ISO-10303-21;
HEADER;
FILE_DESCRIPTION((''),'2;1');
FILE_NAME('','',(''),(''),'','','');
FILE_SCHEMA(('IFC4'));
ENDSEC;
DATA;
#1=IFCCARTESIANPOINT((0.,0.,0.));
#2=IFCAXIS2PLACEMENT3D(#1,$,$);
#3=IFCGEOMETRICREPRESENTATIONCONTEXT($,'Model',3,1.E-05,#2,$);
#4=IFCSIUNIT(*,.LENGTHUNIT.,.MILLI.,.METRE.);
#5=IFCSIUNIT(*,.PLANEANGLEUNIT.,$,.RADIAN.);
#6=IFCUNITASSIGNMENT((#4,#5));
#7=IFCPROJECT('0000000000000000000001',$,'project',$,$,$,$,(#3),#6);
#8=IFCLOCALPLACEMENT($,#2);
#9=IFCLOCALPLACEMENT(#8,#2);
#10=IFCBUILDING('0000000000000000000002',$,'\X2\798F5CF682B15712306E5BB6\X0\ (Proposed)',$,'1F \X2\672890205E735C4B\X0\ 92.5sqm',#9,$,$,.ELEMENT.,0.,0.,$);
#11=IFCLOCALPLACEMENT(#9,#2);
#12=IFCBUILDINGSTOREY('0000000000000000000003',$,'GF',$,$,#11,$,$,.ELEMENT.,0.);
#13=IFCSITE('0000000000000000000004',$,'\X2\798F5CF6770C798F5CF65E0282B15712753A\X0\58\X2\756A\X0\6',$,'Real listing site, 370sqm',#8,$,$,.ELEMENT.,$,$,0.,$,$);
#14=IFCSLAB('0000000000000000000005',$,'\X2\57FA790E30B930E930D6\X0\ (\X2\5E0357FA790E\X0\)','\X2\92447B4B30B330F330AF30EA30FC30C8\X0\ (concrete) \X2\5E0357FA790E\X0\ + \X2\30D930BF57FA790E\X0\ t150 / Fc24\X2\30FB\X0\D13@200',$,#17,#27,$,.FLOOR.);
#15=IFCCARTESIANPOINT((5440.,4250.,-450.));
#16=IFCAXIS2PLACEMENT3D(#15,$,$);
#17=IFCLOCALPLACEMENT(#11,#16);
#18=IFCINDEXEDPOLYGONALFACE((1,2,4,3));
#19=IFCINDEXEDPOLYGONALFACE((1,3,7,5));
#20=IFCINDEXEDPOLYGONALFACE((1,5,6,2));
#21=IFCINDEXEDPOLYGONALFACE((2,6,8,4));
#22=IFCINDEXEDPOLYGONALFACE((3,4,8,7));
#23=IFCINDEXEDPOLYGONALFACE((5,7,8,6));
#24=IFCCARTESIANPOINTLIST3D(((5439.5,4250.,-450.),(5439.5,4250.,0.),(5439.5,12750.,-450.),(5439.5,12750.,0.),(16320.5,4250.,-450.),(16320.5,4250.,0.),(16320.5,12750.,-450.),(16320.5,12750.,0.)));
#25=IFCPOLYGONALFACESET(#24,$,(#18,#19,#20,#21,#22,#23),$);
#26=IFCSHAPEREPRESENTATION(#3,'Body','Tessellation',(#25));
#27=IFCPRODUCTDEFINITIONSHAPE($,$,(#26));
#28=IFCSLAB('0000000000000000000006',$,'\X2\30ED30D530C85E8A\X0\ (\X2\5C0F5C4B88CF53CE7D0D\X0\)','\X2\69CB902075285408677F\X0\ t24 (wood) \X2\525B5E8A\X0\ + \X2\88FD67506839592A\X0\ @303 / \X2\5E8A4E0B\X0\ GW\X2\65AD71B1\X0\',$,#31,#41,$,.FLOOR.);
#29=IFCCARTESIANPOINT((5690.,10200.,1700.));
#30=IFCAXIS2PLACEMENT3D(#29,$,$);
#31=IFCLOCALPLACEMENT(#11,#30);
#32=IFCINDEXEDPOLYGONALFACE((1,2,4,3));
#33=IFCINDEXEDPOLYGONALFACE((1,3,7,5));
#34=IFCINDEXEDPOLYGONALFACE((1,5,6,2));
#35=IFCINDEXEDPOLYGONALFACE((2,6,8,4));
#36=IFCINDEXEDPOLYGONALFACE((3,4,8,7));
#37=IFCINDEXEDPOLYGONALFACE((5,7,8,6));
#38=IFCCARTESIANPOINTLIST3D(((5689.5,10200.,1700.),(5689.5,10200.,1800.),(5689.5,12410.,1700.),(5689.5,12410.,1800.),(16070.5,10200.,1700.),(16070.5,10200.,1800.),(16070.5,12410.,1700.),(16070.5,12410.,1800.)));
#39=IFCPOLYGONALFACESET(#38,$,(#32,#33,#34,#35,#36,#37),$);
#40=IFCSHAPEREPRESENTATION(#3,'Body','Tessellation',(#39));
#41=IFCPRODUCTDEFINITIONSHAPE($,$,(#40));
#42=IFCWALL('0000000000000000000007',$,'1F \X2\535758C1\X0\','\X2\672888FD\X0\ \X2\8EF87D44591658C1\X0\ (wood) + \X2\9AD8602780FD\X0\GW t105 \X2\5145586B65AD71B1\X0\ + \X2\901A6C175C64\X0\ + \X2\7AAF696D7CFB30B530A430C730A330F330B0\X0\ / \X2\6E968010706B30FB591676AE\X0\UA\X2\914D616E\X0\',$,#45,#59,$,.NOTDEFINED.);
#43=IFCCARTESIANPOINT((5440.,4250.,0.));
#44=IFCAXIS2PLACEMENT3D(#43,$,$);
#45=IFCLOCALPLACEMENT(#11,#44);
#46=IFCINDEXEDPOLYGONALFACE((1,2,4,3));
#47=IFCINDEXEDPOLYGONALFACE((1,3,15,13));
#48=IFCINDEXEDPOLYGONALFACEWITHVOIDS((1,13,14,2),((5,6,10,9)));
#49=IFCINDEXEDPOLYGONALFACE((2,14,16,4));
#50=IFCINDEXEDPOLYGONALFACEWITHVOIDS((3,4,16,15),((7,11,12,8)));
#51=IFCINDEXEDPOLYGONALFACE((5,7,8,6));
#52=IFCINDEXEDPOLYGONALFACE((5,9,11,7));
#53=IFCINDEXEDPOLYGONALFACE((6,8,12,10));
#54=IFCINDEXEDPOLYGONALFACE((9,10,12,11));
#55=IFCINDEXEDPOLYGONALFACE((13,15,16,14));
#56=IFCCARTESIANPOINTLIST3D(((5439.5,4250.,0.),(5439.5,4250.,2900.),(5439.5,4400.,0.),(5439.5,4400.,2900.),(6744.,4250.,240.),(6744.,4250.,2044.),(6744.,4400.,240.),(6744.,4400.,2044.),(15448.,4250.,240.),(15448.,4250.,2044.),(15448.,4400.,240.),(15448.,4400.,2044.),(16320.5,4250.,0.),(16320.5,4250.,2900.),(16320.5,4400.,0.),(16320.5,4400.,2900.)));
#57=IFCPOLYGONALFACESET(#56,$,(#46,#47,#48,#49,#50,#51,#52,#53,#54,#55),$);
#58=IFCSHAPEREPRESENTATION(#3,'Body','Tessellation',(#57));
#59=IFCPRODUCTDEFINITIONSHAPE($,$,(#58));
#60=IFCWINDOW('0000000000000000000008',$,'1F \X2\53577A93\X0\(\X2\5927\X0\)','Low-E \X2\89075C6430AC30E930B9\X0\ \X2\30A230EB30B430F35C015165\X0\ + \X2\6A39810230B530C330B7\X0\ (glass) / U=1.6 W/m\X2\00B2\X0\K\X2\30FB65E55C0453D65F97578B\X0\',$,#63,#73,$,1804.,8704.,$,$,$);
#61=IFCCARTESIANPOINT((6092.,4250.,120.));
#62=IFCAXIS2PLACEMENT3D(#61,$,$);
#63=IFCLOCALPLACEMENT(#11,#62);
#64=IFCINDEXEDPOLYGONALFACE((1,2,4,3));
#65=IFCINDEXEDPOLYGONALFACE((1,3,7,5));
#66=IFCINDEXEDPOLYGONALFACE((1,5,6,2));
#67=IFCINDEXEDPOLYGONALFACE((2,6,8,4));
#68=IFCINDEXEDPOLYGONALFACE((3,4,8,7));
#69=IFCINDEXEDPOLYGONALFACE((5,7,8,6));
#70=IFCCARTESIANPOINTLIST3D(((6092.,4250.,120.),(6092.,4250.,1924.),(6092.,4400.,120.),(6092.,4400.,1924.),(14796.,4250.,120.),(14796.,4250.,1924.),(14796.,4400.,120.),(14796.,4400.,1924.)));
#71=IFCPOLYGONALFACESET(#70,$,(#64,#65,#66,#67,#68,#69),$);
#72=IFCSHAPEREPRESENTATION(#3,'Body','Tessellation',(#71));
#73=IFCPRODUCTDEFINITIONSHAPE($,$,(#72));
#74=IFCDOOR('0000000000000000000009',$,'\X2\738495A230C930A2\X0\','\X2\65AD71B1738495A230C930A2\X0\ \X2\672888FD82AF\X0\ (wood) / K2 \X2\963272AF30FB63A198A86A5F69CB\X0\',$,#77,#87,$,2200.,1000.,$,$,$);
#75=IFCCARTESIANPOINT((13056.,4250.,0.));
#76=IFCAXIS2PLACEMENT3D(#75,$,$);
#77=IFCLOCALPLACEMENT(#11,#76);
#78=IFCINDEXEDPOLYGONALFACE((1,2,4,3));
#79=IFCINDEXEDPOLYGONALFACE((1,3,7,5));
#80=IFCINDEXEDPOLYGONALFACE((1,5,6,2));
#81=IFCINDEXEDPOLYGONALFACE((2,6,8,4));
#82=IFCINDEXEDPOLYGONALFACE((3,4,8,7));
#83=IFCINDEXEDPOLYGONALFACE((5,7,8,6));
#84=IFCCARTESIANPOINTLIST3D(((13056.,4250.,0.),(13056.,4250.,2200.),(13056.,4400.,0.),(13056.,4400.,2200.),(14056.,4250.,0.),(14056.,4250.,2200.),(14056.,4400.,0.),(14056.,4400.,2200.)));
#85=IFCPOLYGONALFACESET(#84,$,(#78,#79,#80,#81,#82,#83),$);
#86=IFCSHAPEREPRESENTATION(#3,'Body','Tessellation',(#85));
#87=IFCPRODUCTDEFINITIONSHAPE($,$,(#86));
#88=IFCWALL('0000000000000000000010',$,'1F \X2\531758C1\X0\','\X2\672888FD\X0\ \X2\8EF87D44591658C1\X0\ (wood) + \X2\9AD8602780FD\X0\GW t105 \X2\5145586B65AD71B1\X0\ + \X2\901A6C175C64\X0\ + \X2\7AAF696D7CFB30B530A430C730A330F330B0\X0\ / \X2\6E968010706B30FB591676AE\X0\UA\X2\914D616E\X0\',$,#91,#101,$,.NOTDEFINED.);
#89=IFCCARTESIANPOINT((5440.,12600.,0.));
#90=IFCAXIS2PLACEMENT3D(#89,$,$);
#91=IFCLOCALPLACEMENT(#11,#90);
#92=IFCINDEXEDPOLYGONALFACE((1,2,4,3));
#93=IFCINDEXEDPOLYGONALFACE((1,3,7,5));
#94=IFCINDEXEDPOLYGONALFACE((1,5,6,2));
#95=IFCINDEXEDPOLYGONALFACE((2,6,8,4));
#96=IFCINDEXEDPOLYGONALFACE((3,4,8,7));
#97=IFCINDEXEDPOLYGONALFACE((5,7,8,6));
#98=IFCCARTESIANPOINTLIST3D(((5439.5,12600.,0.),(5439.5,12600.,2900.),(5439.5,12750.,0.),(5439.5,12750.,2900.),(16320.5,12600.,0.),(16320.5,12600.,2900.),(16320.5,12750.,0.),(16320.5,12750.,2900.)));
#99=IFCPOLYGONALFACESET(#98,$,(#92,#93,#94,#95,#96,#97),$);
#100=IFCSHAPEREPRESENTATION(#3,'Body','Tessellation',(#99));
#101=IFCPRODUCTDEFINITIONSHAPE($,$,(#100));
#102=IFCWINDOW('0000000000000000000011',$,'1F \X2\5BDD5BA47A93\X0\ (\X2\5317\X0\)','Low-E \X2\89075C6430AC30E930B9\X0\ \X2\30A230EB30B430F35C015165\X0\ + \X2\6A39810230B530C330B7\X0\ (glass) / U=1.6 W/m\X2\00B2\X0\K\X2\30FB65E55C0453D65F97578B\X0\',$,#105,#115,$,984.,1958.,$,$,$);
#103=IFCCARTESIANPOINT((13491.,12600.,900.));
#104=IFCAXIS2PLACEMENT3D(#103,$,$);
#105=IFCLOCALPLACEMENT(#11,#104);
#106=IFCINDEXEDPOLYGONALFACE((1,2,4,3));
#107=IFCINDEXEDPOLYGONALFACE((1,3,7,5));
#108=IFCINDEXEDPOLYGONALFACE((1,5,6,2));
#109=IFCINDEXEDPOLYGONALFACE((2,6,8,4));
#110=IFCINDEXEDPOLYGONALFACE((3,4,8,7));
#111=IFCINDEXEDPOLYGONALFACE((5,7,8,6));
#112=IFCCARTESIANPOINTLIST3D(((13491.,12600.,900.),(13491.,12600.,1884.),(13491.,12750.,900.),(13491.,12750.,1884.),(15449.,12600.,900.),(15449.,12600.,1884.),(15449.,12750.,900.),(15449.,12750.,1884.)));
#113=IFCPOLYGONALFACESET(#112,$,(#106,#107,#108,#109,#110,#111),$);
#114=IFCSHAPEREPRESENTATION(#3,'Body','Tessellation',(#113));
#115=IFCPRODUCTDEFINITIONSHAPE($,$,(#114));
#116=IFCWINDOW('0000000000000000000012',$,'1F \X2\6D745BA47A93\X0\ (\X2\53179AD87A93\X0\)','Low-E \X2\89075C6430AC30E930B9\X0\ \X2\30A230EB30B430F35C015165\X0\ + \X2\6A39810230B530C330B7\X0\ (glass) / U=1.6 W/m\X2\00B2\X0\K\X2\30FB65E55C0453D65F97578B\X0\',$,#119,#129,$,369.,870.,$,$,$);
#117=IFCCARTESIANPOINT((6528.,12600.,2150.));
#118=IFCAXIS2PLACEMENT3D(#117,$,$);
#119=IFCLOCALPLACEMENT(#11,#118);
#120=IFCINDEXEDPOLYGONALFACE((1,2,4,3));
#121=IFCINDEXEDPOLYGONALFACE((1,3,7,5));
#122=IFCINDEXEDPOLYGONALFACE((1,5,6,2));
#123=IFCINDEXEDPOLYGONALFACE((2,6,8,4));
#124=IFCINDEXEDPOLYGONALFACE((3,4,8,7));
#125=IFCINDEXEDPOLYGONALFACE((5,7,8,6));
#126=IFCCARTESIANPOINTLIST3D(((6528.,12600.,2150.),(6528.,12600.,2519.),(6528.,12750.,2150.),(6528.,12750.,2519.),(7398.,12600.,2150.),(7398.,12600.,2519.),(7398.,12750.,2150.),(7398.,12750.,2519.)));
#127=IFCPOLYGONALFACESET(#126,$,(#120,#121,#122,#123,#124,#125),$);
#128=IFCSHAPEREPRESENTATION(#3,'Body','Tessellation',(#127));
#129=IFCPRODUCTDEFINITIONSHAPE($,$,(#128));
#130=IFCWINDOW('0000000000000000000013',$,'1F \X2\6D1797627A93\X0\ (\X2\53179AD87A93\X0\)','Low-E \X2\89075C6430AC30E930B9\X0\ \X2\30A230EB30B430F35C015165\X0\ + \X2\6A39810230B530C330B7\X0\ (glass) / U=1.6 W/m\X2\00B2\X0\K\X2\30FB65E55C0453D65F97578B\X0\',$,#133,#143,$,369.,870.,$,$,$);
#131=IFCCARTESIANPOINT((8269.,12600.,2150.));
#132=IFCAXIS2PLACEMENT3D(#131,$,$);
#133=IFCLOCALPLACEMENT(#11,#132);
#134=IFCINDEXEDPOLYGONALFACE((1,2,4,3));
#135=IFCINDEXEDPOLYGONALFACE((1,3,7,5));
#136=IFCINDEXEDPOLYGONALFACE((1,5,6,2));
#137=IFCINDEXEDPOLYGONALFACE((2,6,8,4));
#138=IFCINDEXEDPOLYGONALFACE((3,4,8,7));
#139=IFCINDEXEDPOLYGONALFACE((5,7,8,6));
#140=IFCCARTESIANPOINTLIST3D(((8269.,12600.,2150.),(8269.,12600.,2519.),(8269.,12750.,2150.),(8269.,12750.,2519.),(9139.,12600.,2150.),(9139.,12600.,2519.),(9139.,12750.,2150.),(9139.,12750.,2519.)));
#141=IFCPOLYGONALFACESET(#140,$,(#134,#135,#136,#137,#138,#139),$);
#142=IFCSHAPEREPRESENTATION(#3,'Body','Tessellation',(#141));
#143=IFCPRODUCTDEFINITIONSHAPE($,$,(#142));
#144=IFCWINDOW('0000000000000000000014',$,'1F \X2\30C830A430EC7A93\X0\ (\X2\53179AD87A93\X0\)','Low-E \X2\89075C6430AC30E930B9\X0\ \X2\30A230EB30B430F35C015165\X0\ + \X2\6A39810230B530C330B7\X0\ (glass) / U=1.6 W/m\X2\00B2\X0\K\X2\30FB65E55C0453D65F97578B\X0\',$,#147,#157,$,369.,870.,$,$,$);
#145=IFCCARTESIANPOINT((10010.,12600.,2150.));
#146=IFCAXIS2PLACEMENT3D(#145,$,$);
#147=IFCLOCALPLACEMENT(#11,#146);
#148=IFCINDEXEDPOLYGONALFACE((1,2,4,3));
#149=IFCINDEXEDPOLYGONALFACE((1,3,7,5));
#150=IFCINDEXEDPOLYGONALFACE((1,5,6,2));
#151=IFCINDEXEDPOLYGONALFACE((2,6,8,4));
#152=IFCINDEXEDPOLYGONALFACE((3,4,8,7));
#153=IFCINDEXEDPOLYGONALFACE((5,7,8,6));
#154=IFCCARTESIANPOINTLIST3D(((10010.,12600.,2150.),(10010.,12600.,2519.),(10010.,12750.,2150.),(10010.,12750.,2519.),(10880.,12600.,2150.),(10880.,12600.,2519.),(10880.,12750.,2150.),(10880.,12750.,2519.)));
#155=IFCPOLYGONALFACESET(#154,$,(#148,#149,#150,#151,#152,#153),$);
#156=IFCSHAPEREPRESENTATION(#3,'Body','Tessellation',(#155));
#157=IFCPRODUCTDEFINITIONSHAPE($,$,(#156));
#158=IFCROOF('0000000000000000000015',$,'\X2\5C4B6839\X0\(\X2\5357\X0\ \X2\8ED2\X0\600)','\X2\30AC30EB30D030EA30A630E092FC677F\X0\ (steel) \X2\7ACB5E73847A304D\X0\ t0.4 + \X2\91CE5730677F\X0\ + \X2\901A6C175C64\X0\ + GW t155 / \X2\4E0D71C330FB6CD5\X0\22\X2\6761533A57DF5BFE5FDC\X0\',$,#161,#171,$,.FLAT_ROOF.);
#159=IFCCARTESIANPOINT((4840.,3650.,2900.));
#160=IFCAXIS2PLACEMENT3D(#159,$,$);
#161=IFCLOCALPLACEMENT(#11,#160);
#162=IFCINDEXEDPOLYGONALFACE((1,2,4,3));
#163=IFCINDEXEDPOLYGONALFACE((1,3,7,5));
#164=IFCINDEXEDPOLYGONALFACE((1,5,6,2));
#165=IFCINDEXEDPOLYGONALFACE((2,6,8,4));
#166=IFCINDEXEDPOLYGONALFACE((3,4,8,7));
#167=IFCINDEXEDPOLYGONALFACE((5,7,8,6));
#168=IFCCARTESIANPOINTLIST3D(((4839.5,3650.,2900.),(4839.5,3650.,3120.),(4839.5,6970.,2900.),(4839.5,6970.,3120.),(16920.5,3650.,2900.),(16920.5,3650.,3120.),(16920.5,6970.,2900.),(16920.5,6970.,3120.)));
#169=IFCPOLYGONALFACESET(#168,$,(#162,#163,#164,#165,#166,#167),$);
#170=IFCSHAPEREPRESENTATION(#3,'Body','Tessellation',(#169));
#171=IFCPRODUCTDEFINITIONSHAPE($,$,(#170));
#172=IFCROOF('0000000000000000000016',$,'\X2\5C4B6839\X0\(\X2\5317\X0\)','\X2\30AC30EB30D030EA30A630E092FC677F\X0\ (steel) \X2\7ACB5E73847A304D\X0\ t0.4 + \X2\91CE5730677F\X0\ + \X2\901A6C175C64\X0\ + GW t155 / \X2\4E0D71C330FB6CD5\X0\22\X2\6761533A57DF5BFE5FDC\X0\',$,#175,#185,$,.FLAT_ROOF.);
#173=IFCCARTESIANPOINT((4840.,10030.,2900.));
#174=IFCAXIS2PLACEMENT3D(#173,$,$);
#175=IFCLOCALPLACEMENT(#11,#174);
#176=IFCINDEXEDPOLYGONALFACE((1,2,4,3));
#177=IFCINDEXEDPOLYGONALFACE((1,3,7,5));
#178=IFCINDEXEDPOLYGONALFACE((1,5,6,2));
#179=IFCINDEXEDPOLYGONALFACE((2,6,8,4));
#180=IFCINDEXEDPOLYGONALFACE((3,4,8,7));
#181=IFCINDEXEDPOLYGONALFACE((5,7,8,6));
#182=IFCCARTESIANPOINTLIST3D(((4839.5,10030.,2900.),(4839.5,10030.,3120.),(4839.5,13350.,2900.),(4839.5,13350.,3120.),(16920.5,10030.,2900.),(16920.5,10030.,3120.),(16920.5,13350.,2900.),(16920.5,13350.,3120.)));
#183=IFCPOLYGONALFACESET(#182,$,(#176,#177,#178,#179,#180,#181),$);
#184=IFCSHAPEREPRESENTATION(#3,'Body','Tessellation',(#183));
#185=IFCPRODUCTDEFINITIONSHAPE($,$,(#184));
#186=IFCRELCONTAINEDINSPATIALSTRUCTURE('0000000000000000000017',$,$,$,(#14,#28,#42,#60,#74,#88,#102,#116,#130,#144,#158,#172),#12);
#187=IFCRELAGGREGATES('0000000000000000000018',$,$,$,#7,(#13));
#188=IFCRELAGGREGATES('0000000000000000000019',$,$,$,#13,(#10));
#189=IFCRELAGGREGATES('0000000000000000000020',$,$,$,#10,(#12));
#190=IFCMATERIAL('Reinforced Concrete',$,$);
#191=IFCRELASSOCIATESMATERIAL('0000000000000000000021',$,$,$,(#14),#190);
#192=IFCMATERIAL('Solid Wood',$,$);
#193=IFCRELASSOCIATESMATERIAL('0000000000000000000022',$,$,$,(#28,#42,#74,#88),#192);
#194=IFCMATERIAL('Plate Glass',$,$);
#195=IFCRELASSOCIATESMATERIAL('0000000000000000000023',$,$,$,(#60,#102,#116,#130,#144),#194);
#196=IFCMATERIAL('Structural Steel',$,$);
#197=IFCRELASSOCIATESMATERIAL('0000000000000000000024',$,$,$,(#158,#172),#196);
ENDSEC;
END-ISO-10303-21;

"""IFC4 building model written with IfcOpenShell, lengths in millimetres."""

from ifc_helpers import new_model, si_unit, frame, frame_2d, origin, place, context, project, spatial, rectangle, extrude, material, element, fill, save


model = new_model("IFC4")

# Units and contexts
model_context = context("Model", 3, precision=1e-05, world=origin())
ifc_project = project(units=[si_unit("LENGTHUNIT", "METRE", prefix="MILLI"), si_unit("PLANEANGLEUNIT", "RADIAN")], contexts=[model_context])

# Site, building, storey
site_placement = place(None, origin())
site = spatial("IfcSite", under=ifc_project, at=site_placement, Name="福島県福島市花園町58番6", ObjectType="Real listing site, 370sqm", CompositionType="ELEMENT", RefElevation=0.0)
building_placement = place(site_placement, origin())
building = spatial("IfcBuilding", under=site, at=building_placement, Name="福島花園の家 (Proposed)", ObjectType="1F 木造平屋 92.5sqm", CompositionType="ELEMENT", ElevationOfRefHeight=0.0, ElevationOfTerrain=0.0)
storey_placement = place(building_placement, origin())
storey = spatial("IfcBuildingStorey", under=building, at=storey_placement, Name="GF", CompositionType="ELEMENT", Elevation=0.0)

# Slabs
ifc_material_1 = material(Name="Reinforced Concrete")
slab_1_placement = place(storey_placement, frame((5440.0, 4250.0, -450.0)))
element("IfcSlab", 1, at=slab_1_placement, inside=storey, material=ifc_material_1, Name="基礎スラブ (布基礎)", Description="鉄筋コンクリート (concrete) 布基礎 + ベタ基礎 t150 / Fc24・D13@200", PredefinedType="FLOOR", context=model_context, shape_type="SweptSolid", body=[
    extrude(rectangle(XDim=10881.0, YDim=8500.0, at=frame_2d((5440.0, 4250.0))), frame((5440.0, 4250.0, -450.0)), (0.0, 0.0, 1.0), 450.0),
])
ifc_material_2 = material(Name="Solid Wood")
slab_2_placement = place(storey_placement, frame((5690.0, 10200.0, 1700.0)))
element("IfcSlab", 2, at=slab_2_placement, inside=storey, material=ifc_material_2, Name="ロフト床 (小屋裏収納)", Description="構造用合板 t24 (wood) 剛床 + 製材根太 @303 / 床下 GW断熱", PredefinedType="FLOOR", context=model_context, shape_type="SweptSolid", body=[
    extrude(rectangle(XDim=10381.0, YDim=2210.0, at=frame_2d((5190.0, 1105.0))), frame((5690.0, 10200.0, 1700.0)), (0.0, 0.0, 1.0), 100.0),
])

# Wall, openings, window, door
wall_1_placement = place(storey_placement, frame((5440.0, 4250.0, 0.0)))
wall_1 = element("IfcWall", 3, at=wall_1_placement, inside=storey, material=ifc_material_2, Name="1F 南壁", Description="木製 軸組外壁 (wood) + 高性能GW t105 充填断熱 + 通気層 + 窯業系サイディング / 準耐火・外皮UA配慮", PredefinedType="NOTDEFINED", context=model_context, shape_type="SweptSolid", body=[
    extrude(rectangle(XDim=10881.0, YDim=150.0, at=frame_2d((5440.0, 75.0))), frame((5440.0, 4250.0, 0.0)), (0.0, 0.0, 1.0), 2900.0),
])
opening_1_placement = place(storey_placement, frame((6092.0, 4250.0, 120.0)))
opening_1 = element("IfcOpeningElement", 4, at=opening_1_placement, cuts=wall_1, PredefinedType="NOTDEFINED", context=model_context, shape_type="SweptSolid", body=[
    extrude(rectangle(XDim=8704.0, YDim=150.0, at=frame_2d((4352.0, 75.0))), frame((6092.0, 4250.0, 120.0)), (0.0, 0.0, 1.0), 1804.0),
])
opening_2_placement = place(storey_placement, frame((13056.0, 4250.0, 0.0)))
opening_2 = element("IfcOpeningElement", 5, at=opening_2_placement, cuts=wall_1, PredefinedType="NOTDEFINED", context=model_context, shape_type="SweptSolid", body=[
    extrude(rectangle(XDim=1000.0, YDim=150.0, at=frame_2d((500.0, 75.0))), frame((13056.0, 4250.0, 0.0)), (0.0, 0.0, 1.0), 2200.0),
])
ifc_material_3 = material(Name="Plate Glass")
window_1_placement = place(storey_placement, frame((6092.0, 4250.0, 120.0)))
window_1 = element("IfcWindow", 6, at=window_1_placement, inside=storey, material=ifc_material_3, Name="1F 南窓(大)", Description="Low-E 複層ガラス アルゴン封入 + 樹脂サッシ (glass) / U=1.6 W/m²K・日射取得型", OverallHeight=1804.0, OverallWidth=8704.0, context=model_context, shape_type="SweptSolid", body=[
    extrude(rectangle(XDim=8704.0, YDim=150.0, at=frame_2d((4352.0, 75.0))), frame((6092.0, 4250.0, 120.0)), (0.0, 0.0, 1.0), 1804.0),
])
fill(opening_1, window_1)
door_1_placement = place(storey_placement, frame((13056.0, 4250.0, 0.0)))
door_1 = element("IfcDoor", 7, at=door_1_placement, inside=storey, material=ifc_material_2, Name="玄関ドア", Description="断熱玄関ドア 木製芯 (wood) / K2 防犯・採風機構", OverallHeight=2200.0, OverallWidth=1000.0, context=model_context, shape_type="SweptSolid", body=[
    extrude(rectangle(XDim=1000.0, YDim=150.0, at=frame_2d((500.0, 75.0))), frame((13056.0, 4250.0, 0.0)), (0.0, 0.0, 1.0), 2200.0),
])
fill(opening_2, door_1)

# Wall, openings, windows
wall_2_placement = place(storey_placement, frame((5440.0, 12600.0, 0.0)))
wall_2 = element("IfcWall", 8, at=wall_2_placement, inside=storey, material=ifc_material_2, Name="1F 北壁", Description="木製 軸組外壁 (wood) + 高性能GW t105 充填断熱 + 通気層 + 窯業系サイディング / 準耐火・外皮UA配慮", PredefinedType="NOTDEFINED", context=model_context, shape_type="SweptSolid", body=[
    extrude(rectangle(XDim=10881.0, YDim=150.0, at=frame_2d((5440.0, 75.0))), frame((5440.0, 12600.0, 0.0)), (0.0, 0.0, 1.0), 2900.0),
])
opening_3_placement = place(storey_placement, frame((13491.0, 12600.0, 900.0)))
opening_3 = element("IfcOpeningElement", 9, at=opening_3_placement, cuts=wall_2, PredefinedType="NOTDEFINED", context=model_context, shape_type="SweptSolid", body=[
    extrude(rectangle(XDim=1958.0, YDim=150.0, at=frame_2d((979.0, 75.0))), frame((13491.0, 12600.0, 900.0)), (0.0, 0.0, 1.0), 984.0),
])
opening_4_placement = place(storey_placement, frame((6528.0, 12600.0, 2150.0)))
opening_4 = element("IfcOpeningElement", 10, at=opening_4_placement, cuts=wall_2, PredefinedType="NOTDEFINED", context=model_context, shape_type="SweptSolid", body=[
    extrude(rectangle(XDim=870.0, YDim=150.0, at=frame_2d((435.0, 75.0))), frame((6528.0, 12600.0, 2150.0)), (0.0, 0.0, 1.0), 369.0),
])
opening_5_placement = place(storey_placement, frame((8269.0, 12600.0, 2150.0)))
opening_5 = element("IfcOpeningElement", 11, at=opening_5_placement, cuts=wall_2, PredefinedType="NOTDEFINED", context=model_context, shape_type="SweptSolid", body=[
    extrude(rectangle(XDim=870.0, YDim=150.0, at=frame_2d((435.0, 75.0))), frame((8269.0, 12600.0, 2150.0)), (0.0, 0.0, 1.0), 369.0),
])
opening_6_placement = place(storey_placement, frame((10010.0, 12600.0, 2150.0)))
opening_6 = element("IfcOpeningElement", 12, at=opening_6_placement, cuts=wall_2, PredefinedType="NOTDEFINED", context=model_context, shape_type="SweptSolid", body=[
    extrude(rectangle(XDim=870.0, YDim=150.0, at=frame_2d((435.0, 75.0))), frame((10010.0, 12600.0, 2150.0)), (0.0, 0.0, 1.0), 369.0),
])
window_2_placement = place(storey_placement, frame((13491.0, 12600.0, 900.0)))
window_2 = element("IfcWindow", 13, at=window_2_placement, inside=storey, material=ifc_material_3, Name="1F 寝室窓 (北)", Description="Low-E 複層ガラス アルゴン封入 + 樹脂サッシ (glass) / U=1.6 W/m²K・日射取得型", OverallHeight=984.0, OverallWidth=1958.0, context=model_context, shape_type="SweptSolid", body=[
    extrude(rectangle(XDim=1958.0, YDim=150.0, at=frame_2d((979.0, 75.0))), frame((13491.0, 12600.0, 900.0)), (0.0, 0.0, 1.0), 984.0),
])
fill(opening_3, window_2)
window_3_placement = place(storey_placement, frame((6528.0, 12600.0, 2150.0)))
window_3 = element("IfcWindow", 14, at=window_3_placement, inside=storey, material=ifc_material_3, Name="1F 浴室窓 (北高窓)", Description="Low-E 複層ガラス アルゴン封入 + 樹脂サッシ (glass) / U=1.6 W/m²K・日射取得型", OverallHeight=369.0, OverallWidth=870.0, context=model_context, shape_type="SweptSolid", body=[
    extrude(rectangle(XDim=870.0, YDim=150.0, at=frame_2d((435.0, 75.0))), frame((6528.0, 12600.0, 2150.0)), (0.0, 0.0, 1.0), 369.0),
])
fill(opening_4, window_3)
window_4_placement = place(storey_placement, frame((8269.0, 12600.0, 2150.0)))
window_4 = element("IfcWindow", 15, at=window_4_placement, inside=storey, material=ifc_material_3, Name="1F 洗面窓 (北高窓)", Description="Low-E 複層ガラス アルゴン封入 + 樹脂サッシ (glass) / U=1.6 W/m²K・日射取得型", OverallHeight=369.0, OverallWidth=870.0, context=model_context, shape_type="SweptSolid", body=[
    extrude(rectangle(XDim=870.0, YDim=150.0, at=frame_2d((435.0, 75.0))), frame((8269.0, 12600.0, 2150.0)), (0.0, 0.0, 1.0), 369.0),
])
fill(opening_5, window_4)
window_5_placement = place(storey_placement, frame((10010.0, 12600.0, 2150.0)))
window_5 = element("IfcWindow", 16, at=window_5_placement, inside=storey, material=ifc_material_3, Name="1F トイレ窓 (北高窓)", Description="Low-E 複層ガラス アルゴン封入 + 樹脂サッシ (glass) / U=1.6 W/m²K・日射取得型", OverallHeight=369.0, OverallWidth=870.0, context=model_context, shape_type="SweptSolid", body=[
    extrude(rectangle(XDim=870.0, YDim=150.0, at=frame_2d((435.0, 75.0))), frame((10010.0, 12600.0, 2150.0)), (0.0, 0.0, 1.0), 369.0),
])
fill(opening_6, window_5)

# Roofs
ifc_material_4 = material(Name="Structural Steel")
roof_1_placement = place(storey_placement, frame((4840.0, 3650.0, 2900.0)))
element("IfcRoof", 17, at=roof_1_placement, inside=storey, material=ifc_material_4, Name="屋根(南 軒600)", Description="ガルバリウム鋼板 (steel) 立平葺き t0.4 + 野地板 + 通気層 + GW t155 / 不燃・法22条区域対応", PredefinedType="FLAT_ROOF", context=model_context, shape_type="SweptSolid", body=[
    extrude(rectangle(XDim=12081.0, YDim=3320.0, at=frame_2d((6040.0, 1660.0))), frame((4840.0, 3650.0, 2900.0)), (0.0, 0.0, 1.0), 220.0),
])
roof_2_placement = place(storey_placement, frame((4840.0, 10030.0, 2900.0)))
element("IfcRoof", 18, at=roof_2_placement, inside=storey, material=ifc_material_4, Name="屋根(北)", Description="ガルバリウム鋼板 (steel) 立平葺き t0.4 + 野地板 + 通気層 + GW t155 / 不燃・法22条区域対応", PredefinedType="FLAT_ROOF", context=model_context, shape_type="SweptSolid", body=[
    extrude(rectangle(XDim=12081.0, YDim=3320.0, at=frame_2d((6040.0, 1660.0))), frame((4840.0, 10030.0, 2900.0)), (0.0, 0.0, 1.0), 220.0),
])

save(model, "model.ifc")
